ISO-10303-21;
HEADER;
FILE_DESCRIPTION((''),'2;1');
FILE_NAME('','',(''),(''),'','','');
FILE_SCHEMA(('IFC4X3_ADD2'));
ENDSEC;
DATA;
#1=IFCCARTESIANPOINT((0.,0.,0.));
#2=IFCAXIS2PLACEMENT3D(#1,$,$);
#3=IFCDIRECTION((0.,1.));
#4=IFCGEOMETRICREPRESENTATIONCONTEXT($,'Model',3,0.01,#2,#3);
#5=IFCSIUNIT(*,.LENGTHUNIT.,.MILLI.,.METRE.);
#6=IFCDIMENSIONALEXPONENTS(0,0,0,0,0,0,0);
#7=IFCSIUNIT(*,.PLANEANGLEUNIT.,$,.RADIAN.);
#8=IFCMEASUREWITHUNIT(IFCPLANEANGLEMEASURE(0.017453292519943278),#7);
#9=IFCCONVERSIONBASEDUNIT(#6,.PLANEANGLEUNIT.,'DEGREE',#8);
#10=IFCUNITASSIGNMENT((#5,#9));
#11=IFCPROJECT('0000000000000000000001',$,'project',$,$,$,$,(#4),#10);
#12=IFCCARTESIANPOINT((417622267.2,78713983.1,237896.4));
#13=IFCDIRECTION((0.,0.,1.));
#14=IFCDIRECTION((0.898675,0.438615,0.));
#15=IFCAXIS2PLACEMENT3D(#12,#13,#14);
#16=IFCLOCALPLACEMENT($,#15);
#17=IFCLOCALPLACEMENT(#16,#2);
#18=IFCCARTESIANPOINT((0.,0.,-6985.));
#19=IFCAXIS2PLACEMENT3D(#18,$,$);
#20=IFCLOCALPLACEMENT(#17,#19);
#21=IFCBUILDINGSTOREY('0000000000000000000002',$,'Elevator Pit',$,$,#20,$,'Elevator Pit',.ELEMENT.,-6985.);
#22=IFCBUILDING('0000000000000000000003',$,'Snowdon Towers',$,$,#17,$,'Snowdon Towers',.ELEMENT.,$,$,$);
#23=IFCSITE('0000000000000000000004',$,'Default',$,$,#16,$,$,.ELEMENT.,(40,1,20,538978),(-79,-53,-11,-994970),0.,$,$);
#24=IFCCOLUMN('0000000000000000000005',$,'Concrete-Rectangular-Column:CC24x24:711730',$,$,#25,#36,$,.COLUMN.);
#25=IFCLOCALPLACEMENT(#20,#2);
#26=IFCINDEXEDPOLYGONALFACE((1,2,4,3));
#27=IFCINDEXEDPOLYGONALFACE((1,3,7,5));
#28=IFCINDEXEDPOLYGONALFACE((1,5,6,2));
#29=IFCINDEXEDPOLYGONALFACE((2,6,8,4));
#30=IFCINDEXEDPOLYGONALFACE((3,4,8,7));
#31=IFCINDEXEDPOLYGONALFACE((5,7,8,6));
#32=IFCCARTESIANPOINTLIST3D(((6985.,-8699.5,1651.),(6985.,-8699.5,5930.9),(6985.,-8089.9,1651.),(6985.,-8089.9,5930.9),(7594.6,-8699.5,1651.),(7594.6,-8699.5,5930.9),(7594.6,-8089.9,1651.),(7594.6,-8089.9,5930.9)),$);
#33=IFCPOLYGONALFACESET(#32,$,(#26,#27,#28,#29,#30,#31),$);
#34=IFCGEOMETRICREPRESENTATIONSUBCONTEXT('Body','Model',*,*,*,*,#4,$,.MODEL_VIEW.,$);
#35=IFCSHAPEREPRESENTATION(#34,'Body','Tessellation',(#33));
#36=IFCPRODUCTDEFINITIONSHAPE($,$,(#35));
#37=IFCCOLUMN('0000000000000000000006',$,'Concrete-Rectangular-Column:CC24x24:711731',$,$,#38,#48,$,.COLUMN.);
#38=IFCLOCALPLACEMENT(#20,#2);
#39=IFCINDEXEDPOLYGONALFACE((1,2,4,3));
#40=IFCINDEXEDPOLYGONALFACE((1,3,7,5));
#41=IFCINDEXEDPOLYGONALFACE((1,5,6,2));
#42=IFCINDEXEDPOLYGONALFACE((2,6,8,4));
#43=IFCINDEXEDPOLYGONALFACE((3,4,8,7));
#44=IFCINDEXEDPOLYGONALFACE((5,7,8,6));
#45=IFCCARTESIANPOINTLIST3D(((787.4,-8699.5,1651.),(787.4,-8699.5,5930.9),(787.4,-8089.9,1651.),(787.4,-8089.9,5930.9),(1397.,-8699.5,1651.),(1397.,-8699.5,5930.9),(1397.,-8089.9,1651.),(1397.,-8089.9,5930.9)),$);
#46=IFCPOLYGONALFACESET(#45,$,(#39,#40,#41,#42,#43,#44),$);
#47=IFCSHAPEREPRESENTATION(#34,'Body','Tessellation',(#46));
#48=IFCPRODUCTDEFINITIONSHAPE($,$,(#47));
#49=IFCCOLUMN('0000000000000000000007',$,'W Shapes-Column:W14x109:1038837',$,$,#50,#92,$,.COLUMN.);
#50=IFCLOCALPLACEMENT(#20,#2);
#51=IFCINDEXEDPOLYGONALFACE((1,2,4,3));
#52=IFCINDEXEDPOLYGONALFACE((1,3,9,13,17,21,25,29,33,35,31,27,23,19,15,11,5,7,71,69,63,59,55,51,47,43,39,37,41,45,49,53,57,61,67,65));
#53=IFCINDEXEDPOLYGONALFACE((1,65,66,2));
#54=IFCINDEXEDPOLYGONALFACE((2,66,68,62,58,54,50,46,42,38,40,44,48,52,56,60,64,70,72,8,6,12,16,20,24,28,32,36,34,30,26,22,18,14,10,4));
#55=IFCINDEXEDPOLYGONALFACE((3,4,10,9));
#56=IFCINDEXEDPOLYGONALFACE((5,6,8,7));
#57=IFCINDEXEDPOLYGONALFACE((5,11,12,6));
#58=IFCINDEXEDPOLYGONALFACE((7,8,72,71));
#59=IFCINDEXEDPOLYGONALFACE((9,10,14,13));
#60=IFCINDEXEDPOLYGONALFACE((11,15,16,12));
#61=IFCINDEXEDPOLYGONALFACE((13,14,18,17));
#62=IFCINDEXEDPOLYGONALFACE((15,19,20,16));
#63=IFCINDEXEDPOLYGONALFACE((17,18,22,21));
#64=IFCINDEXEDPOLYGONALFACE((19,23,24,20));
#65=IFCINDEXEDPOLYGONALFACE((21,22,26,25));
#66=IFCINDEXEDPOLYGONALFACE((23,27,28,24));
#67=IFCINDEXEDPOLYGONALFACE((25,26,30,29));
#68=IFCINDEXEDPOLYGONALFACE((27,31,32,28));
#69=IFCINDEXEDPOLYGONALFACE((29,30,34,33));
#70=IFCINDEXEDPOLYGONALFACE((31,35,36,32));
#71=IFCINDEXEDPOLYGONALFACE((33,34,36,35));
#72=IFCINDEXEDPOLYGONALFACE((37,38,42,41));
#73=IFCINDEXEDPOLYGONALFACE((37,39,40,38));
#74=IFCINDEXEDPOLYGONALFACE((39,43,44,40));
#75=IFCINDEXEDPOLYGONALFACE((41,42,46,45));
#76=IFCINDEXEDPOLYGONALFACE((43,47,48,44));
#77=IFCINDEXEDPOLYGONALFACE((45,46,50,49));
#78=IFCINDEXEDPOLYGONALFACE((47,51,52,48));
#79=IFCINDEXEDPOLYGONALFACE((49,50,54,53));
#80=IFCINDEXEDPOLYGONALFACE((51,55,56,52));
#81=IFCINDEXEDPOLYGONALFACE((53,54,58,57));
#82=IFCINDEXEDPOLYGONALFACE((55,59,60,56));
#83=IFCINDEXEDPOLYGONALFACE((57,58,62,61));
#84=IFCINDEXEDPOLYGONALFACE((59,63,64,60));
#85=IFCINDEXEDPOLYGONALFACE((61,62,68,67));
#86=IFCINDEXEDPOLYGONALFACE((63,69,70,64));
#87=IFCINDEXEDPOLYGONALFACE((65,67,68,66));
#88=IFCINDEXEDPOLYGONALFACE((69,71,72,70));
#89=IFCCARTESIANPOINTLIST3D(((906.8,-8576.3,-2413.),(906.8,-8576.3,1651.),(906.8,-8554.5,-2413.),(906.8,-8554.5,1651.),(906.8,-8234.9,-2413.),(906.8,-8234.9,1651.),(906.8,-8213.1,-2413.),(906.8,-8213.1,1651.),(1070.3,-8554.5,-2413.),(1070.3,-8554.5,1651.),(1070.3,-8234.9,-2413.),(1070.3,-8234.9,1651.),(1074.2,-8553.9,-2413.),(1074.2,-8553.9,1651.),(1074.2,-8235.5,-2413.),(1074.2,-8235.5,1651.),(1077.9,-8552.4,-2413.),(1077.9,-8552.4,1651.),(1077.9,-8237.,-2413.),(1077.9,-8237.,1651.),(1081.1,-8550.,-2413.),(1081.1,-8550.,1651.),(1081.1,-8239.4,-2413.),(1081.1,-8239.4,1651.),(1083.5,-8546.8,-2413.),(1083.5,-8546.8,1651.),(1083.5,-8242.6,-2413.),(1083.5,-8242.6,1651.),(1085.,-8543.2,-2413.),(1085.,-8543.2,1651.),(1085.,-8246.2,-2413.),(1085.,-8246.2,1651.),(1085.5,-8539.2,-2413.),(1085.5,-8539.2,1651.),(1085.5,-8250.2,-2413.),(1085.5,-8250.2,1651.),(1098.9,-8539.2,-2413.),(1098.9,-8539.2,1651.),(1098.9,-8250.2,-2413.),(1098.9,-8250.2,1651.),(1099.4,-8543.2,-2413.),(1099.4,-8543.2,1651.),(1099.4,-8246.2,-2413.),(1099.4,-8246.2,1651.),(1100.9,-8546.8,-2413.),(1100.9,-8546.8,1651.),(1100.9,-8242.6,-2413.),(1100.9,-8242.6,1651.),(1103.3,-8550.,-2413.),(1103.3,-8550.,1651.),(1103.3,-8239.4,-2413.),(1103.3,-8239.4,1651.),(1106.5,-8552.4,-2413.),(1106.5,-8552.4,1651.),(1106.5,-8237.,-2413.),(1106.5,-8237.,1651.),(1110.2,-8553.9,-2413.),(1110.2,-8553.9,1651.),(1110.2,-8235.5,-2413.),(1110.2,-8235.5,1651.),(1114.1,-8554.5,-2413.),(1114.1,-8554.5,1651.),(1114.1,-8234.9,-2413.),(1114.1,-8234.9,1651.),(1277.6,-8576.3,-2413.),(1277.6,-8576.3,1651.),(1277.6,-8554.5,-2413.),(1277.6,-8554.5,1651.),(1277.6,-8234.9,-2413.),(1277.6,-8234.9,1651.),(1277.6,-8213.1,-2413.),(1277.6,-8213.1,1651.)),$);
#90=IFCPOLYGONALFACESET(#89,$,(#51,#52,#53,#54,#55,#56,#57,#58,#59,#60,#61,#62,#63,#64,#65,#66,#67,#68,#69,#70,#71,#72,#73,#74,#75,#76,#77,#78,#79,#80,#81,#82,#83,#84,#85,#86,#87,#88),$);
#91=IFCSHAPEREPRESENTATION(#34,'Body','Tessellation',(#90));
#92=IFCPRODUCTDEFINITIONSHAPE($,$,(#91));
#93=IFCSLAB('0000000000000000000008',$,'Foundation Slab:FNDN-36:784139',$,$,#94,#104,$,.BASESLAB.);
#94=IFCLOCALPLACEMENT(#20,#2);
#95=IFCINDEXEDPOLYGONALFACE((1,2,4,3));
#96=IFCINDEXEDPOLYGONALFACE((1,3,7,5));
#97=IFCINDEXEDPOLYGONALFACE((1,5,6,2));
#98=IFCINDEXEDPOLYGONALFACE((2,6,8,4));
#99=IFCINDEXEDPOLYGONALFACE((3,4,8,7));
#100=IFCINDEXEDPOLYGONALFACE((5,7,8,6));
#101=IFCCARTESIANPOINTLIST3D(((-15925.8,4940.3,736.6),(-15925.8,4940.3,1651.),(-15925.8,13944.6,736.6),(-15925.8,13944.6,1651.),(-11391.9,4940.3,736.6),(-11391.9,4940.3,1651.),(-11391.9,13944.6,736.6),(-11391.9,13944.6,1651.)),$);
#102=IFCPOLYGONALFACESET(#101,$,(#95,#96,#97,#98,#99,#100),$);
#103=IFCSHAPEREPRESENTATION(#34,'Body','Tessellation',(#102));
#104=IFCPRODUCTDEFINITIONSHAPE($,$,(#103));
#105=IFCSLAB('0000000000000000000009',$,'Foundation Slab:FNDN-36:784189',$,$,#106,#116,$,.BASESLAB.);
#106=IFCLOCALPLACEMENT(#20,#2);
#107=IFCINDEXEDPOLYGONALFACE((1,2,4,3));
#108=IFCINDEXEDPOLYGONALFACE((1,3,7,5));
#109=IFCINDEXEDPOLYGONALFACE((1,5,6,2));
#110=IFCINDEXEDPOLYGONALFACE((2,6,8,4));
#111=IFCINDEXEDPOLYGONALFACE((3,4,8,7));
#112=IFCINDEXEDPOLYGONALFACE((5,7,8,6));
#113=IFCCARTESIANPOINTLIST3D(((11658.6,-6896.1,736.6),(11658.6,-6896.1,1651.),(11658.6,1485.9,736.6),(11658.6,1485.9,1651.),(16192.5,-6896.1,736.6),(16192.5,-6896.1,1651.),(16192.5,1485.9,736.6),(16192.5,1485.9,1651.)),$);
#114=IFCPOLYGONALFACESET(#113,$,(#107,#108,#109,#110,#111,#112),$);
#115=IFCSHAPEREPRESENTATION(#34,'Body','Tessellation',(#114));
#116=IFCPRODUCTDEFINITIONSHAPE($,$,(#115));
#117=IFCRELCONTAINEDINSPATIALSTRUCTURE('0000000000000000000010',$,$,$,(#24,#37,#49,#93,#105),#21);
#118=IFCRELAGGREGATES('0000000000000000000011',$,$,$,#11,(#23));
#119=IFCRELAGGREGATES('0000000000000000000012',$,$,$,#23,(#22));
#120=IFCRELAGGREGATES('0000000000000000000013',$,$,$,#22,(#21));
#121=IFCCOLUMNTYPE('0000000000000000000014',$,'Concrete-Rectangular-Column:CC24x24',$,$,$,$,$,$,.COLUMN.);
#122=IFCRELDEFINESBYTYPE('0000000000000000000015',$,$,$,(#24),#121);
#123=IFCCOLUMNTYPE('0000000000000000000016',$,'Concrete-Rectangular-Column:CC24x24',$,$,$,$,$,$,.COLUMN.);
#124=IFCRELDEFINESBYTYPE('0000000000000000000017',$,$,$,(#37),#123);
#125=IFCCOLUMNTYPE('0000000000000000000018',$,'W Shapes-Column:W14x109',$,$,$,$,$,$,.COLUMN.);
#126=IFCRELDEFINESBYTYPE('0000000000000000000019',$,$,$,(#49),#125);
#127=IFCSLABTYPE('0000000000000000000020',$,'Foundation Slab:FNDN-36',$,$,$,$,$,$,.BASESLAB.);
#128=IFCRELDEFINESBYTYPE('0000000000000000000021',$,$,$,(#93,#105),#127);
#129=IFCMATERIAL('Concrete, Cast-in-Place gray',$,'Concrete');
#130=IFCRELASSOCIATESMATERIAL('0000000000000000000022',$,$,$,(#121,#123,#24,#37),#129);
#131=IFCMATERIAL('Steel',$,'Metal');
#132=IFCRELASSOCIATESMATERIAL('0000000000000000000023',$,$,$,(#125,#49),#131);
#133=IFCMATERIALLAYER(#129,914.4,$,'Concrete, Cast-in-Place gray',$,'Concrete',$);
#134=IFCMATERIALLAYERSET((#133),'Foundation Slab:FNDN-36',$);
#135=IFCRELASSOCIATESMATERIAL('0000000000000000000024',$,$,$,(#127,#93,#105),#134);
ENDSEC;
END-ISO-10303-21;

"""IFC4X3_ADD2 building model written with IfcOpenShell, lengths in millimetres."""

from ifc_helpers import new_model, entity, si_unit, converted_unit, direction, frame, frame_2d, origin, origin_2d_with_axis, place, context, subcontext, project, spatial, rectangle, i_section, extrude, source, transform, mapped, material, layer, layer_set, layer_usage, material_profile, profile_set, profile_usage, type_object, type_shapes, element, save


model = new_model("IFC4X3_ADD2")

# Units and contexts
model_context = context("Model", 3, precision=0.01, world=origin(), true_north=direction((0.0, 1.0)))
body_context = subcontext(model_context, "Body", "Model", "MODEL_VIEW")
ifc_project = project(units=[si_unit("LENGTHUNIT", "METRE", prefix="MILLI"), converted_unit("PLANEANGLEUNIT", "DEGREE", entity("IfcPlaneAngleMeasure", 0.017453292519943278), si_unit("PLANEANGLEUNIT", "RADIAN"), dimensions=[0, 0, 0, 0, 0, 0, 0])], contexts=[model_context])

# Site, building, storey
site_placement = place(None, frame((417622267.2, 78713983.1, 237896.4), z_axis=(0.0, 0.0, 1.0), x_axis=(0.898675, 0.438615, 0.0)))
site = spatial("IfcSite", under=ifc_project, at=site_placement, Name="Default", CompositionType="ELEMENT", RefLatitude=(40, 1, 20, 538978), RefLongitude=(-79, -53, -11, -994970), RefElevation=0.0)
building_placement = place(site_placement, origin())
building = spatial("IfcBuilding", under=site, at=building_placement, Name="Snowdon Towers", LongName="Snowdon Towers", CompositionType="ELEMENT")
storey_placement = place(building_placement, frame((0.0, 0.0, -6985.0)))
storey = spatial("IfcBuildingStorey", under=building, at=storey_placement, Name="Elevator Pit", LongName="Elevator Pit", CompositionType="ELEMENT", Elevation=-6985.0)

# Shared definitions
ifc_material_1 = material(Name="Concrete, Cast-in-Place gray", Category="Concrete")

# Columns
ifc_material_profile_1 = material_profile(ifc_material_1, rectangle(XDim=609.6, YDim=609.6, at=origin_2d_with_axis()), Name="CC24x24")
ifc_profile_set_1 = profile_set([ifc_material_profile_1], Name="CC24x24")
ifc_profile_usage_1 = profile_usage(ifc_profile_set_1)
column_type_1 = type_object("IfcColumnType", Name="Concrete-Rectangular-Column:CC24x24", PredefinedType="COLUMN", material=ifc_profile_set_1)
shared_shape_1 = source(origin(), body_context, "Body", "SweptSolid", [
    extrude(rectangle(XDim=609.6, YDim=609.6, at=origin_2d_with_axis()), frame((7289.8, -8394.7, -5334.0), z_axis=(0.0, 0.0, 1.0), x_axis=(-1.0, 0.0, 0.0)), (0.0, 0.0, 1.0), 4279.9),
])
type_shapes(column_type_1, [shared_shape_1])
column_1_placement = place(storey_placement, frame((0.0, 0.0, 6985.0)))
element("IfcColumn", 1, at=column_1_placement, inside=storey, type_object=column_type_1, material=ifc_profile_usage_1, Name="Concrete-Rectangular-Column:CC24x24:711730", PredefinedType="COLUMN", context=body_context, shape_type="MappedRepresentation", body=[
    mapped(shared_shape_1, transform((0.0, 0.0, 0.0), scale=1.0)),
])
column_type_2 = type_object("IfcColumnType", Name="Concrete-Rectangular-Column:CC24x24", PredefinedType="COLUMN", material=ifc_profile_set_1)
shared_shape_2 = source(origin(), body_context, "Body", "SweptSolid", [
    extrude(rectangle(XDim=609.6, YDim=609.6, at=origin_2d_with_axis()), frame((1092.2, -8394.7, -5334.0), z_axis=(0.0, 0.0, 1.0), x_axis=(-1.0, 0.0, 0.0)), (0.0, 0.0, 1.0), 4279.9),
])
type_shapes(column_type_2, [shared_shape_2])
column_2_placement = place(storey_placement, frame((0.0, 0.0, 6985.0)))
element("IfcColumn", 2, at=column_2_placement, inside=storey, type_object=column_type_2, material=ifc_profile_usage_1, Name="Concrete-Rectangular-Column:CC24x24:711731", PredefinedType="COLUMN", context=body_context, shape_type="MappedRepresentation", body=[
    mapped(shared_shape_2, transform((0.0, 0.0, 0.0), scale=1.0)),
])
ifc_material_2 = material(Name="Steel", Category="Metal")
ifc_material_profile_2 = material_profile(ifc_material_2, i_section(OverallWidth=370.8, OverallDepth=363.2, WebThickness=13.3, FlangeThickness=21.8, FilletRadius=15.2, at=frame_2d((0.0, 0.0), x_axis=(1.0, 0.0))), Name="W14x109")
ifc_profile_set_2 = profile_set([ifc_material_profile_2], Name="W14x109")
ifc_profile_usage_2 = profile_usage(ifc_profile_set_2)
column_type_3 = type_object("IfcColumnType", Name="W Shapes-Column:W14x109", PredefinedType="COLUMN", material=ifc_profile_set_2)
shared_shape_3 = source(origin(), body_context, "Body", "SweptSolid", [
    extrude(i_section(OverallWidth=370.8, OverallDepth=363.2, WebThickness=13.3, FlangeThickness=21.8, FilletRadius=15.2, at=frame_2d((0.0, 0.0), x_axis=(1.0, 0.0))), frame((0.0, 0.0, -9398.0), z_axis=(0.0, 0.0, 1.0), x_axis=(-1.0, 0.0, 0.0)), (0.0, 0.0, 1.0), 4064.0),
])
type_shapes(column_type_3, [shared_shape_3])
column_3_placement = place(storey_placement, frame((1092.2, -8394.7, 6985.0), z_axis=(0.0, 0.0, 1.0), x_axis=(-1.0, 0.0, 0.0)))
element("IfcColumn", 3, at=column_3_placement, inside=storey, type_object=column_type_3, material=ifc_profile_usage_2, Name="W Shapes-Column:W14x109:1038837", PredefinedType="COLUMN", context=body_context, shape_type="MappedRepresentation", body=[
    mapped(shared_shape_3, transform((0.0, 0.0, 0.0), scale=1.0)),
])

# Slabs
ifc_layer = layer(ifc_material_1, 914.4, Name="Concrete, Cast-in-Place gray", Category="Concrete")
ifc_layer_set = layer_set([ifc_layer], Name="Foundation Slab:FNDN-36")
slab_type_1 = type_object("IfcSlabType", Name="Foundation Slab:FNDN-36", PredefinedType="BASESLAB", material=ifc_layer_set)
ifc_layer_usage_1 = layer_usage(ifc_layer_set, "AXIS3", "POSITIVE", 0.0)
slab_1_placement = place(storey_placement, origin())
element("IfcSlab", 4, at=slab_1_placement, inside=storey, type_object=slab_type_1, material=ifc_layer_usage_1, Name="Foundation Slab:FNDN-36:784139", PredefinedType="BASESLAB", context=body_context, shape_type="SweptSolid", body=[
    extrude(rectangle(XDim=9004.3, YDim=4533.9, at=frame_2d((0.0, 0.0), x_axis=(1.0, 0.0))), frame((-13658.8, 9442.5, 1651.0), z_axis=(0.0, 0.0, -1.0), x_axis=(0.0, 1.0, 0.0)), (0.0, 0.0, 1.0), 914.4),
])
ifc_layer_usage_2 = layer_usage(ifc_layer_set, "AXIS3", "POSITIVE", 0.0)
slab_2_placement = place(storey_placement, origin())
element("IfcSlab", 5, at=slab_2_placement, inside=storey, type_object=slab_type_1, material=ifc_layer_usage_2, Name="Foundation Slab:FNDN-36:784189", PredefinedType="BASESLAB", context=body_context, shape_type="SweptSolid", body=[
    extrude(rectangle(XDim=8382.0, YDim=4533.9, at=frame_2d((0.0, 0.0), x_axis=(1.0, 0.0))), frame((13925.6, -2705.1, 1651.0), z_axis=(0.0, 0.0, -1.0), x_axis=(0.0, 1.0, 0.0)), (0.0, 0.0, 1.0), 914.4),
])

save(model, "model.ifc")
